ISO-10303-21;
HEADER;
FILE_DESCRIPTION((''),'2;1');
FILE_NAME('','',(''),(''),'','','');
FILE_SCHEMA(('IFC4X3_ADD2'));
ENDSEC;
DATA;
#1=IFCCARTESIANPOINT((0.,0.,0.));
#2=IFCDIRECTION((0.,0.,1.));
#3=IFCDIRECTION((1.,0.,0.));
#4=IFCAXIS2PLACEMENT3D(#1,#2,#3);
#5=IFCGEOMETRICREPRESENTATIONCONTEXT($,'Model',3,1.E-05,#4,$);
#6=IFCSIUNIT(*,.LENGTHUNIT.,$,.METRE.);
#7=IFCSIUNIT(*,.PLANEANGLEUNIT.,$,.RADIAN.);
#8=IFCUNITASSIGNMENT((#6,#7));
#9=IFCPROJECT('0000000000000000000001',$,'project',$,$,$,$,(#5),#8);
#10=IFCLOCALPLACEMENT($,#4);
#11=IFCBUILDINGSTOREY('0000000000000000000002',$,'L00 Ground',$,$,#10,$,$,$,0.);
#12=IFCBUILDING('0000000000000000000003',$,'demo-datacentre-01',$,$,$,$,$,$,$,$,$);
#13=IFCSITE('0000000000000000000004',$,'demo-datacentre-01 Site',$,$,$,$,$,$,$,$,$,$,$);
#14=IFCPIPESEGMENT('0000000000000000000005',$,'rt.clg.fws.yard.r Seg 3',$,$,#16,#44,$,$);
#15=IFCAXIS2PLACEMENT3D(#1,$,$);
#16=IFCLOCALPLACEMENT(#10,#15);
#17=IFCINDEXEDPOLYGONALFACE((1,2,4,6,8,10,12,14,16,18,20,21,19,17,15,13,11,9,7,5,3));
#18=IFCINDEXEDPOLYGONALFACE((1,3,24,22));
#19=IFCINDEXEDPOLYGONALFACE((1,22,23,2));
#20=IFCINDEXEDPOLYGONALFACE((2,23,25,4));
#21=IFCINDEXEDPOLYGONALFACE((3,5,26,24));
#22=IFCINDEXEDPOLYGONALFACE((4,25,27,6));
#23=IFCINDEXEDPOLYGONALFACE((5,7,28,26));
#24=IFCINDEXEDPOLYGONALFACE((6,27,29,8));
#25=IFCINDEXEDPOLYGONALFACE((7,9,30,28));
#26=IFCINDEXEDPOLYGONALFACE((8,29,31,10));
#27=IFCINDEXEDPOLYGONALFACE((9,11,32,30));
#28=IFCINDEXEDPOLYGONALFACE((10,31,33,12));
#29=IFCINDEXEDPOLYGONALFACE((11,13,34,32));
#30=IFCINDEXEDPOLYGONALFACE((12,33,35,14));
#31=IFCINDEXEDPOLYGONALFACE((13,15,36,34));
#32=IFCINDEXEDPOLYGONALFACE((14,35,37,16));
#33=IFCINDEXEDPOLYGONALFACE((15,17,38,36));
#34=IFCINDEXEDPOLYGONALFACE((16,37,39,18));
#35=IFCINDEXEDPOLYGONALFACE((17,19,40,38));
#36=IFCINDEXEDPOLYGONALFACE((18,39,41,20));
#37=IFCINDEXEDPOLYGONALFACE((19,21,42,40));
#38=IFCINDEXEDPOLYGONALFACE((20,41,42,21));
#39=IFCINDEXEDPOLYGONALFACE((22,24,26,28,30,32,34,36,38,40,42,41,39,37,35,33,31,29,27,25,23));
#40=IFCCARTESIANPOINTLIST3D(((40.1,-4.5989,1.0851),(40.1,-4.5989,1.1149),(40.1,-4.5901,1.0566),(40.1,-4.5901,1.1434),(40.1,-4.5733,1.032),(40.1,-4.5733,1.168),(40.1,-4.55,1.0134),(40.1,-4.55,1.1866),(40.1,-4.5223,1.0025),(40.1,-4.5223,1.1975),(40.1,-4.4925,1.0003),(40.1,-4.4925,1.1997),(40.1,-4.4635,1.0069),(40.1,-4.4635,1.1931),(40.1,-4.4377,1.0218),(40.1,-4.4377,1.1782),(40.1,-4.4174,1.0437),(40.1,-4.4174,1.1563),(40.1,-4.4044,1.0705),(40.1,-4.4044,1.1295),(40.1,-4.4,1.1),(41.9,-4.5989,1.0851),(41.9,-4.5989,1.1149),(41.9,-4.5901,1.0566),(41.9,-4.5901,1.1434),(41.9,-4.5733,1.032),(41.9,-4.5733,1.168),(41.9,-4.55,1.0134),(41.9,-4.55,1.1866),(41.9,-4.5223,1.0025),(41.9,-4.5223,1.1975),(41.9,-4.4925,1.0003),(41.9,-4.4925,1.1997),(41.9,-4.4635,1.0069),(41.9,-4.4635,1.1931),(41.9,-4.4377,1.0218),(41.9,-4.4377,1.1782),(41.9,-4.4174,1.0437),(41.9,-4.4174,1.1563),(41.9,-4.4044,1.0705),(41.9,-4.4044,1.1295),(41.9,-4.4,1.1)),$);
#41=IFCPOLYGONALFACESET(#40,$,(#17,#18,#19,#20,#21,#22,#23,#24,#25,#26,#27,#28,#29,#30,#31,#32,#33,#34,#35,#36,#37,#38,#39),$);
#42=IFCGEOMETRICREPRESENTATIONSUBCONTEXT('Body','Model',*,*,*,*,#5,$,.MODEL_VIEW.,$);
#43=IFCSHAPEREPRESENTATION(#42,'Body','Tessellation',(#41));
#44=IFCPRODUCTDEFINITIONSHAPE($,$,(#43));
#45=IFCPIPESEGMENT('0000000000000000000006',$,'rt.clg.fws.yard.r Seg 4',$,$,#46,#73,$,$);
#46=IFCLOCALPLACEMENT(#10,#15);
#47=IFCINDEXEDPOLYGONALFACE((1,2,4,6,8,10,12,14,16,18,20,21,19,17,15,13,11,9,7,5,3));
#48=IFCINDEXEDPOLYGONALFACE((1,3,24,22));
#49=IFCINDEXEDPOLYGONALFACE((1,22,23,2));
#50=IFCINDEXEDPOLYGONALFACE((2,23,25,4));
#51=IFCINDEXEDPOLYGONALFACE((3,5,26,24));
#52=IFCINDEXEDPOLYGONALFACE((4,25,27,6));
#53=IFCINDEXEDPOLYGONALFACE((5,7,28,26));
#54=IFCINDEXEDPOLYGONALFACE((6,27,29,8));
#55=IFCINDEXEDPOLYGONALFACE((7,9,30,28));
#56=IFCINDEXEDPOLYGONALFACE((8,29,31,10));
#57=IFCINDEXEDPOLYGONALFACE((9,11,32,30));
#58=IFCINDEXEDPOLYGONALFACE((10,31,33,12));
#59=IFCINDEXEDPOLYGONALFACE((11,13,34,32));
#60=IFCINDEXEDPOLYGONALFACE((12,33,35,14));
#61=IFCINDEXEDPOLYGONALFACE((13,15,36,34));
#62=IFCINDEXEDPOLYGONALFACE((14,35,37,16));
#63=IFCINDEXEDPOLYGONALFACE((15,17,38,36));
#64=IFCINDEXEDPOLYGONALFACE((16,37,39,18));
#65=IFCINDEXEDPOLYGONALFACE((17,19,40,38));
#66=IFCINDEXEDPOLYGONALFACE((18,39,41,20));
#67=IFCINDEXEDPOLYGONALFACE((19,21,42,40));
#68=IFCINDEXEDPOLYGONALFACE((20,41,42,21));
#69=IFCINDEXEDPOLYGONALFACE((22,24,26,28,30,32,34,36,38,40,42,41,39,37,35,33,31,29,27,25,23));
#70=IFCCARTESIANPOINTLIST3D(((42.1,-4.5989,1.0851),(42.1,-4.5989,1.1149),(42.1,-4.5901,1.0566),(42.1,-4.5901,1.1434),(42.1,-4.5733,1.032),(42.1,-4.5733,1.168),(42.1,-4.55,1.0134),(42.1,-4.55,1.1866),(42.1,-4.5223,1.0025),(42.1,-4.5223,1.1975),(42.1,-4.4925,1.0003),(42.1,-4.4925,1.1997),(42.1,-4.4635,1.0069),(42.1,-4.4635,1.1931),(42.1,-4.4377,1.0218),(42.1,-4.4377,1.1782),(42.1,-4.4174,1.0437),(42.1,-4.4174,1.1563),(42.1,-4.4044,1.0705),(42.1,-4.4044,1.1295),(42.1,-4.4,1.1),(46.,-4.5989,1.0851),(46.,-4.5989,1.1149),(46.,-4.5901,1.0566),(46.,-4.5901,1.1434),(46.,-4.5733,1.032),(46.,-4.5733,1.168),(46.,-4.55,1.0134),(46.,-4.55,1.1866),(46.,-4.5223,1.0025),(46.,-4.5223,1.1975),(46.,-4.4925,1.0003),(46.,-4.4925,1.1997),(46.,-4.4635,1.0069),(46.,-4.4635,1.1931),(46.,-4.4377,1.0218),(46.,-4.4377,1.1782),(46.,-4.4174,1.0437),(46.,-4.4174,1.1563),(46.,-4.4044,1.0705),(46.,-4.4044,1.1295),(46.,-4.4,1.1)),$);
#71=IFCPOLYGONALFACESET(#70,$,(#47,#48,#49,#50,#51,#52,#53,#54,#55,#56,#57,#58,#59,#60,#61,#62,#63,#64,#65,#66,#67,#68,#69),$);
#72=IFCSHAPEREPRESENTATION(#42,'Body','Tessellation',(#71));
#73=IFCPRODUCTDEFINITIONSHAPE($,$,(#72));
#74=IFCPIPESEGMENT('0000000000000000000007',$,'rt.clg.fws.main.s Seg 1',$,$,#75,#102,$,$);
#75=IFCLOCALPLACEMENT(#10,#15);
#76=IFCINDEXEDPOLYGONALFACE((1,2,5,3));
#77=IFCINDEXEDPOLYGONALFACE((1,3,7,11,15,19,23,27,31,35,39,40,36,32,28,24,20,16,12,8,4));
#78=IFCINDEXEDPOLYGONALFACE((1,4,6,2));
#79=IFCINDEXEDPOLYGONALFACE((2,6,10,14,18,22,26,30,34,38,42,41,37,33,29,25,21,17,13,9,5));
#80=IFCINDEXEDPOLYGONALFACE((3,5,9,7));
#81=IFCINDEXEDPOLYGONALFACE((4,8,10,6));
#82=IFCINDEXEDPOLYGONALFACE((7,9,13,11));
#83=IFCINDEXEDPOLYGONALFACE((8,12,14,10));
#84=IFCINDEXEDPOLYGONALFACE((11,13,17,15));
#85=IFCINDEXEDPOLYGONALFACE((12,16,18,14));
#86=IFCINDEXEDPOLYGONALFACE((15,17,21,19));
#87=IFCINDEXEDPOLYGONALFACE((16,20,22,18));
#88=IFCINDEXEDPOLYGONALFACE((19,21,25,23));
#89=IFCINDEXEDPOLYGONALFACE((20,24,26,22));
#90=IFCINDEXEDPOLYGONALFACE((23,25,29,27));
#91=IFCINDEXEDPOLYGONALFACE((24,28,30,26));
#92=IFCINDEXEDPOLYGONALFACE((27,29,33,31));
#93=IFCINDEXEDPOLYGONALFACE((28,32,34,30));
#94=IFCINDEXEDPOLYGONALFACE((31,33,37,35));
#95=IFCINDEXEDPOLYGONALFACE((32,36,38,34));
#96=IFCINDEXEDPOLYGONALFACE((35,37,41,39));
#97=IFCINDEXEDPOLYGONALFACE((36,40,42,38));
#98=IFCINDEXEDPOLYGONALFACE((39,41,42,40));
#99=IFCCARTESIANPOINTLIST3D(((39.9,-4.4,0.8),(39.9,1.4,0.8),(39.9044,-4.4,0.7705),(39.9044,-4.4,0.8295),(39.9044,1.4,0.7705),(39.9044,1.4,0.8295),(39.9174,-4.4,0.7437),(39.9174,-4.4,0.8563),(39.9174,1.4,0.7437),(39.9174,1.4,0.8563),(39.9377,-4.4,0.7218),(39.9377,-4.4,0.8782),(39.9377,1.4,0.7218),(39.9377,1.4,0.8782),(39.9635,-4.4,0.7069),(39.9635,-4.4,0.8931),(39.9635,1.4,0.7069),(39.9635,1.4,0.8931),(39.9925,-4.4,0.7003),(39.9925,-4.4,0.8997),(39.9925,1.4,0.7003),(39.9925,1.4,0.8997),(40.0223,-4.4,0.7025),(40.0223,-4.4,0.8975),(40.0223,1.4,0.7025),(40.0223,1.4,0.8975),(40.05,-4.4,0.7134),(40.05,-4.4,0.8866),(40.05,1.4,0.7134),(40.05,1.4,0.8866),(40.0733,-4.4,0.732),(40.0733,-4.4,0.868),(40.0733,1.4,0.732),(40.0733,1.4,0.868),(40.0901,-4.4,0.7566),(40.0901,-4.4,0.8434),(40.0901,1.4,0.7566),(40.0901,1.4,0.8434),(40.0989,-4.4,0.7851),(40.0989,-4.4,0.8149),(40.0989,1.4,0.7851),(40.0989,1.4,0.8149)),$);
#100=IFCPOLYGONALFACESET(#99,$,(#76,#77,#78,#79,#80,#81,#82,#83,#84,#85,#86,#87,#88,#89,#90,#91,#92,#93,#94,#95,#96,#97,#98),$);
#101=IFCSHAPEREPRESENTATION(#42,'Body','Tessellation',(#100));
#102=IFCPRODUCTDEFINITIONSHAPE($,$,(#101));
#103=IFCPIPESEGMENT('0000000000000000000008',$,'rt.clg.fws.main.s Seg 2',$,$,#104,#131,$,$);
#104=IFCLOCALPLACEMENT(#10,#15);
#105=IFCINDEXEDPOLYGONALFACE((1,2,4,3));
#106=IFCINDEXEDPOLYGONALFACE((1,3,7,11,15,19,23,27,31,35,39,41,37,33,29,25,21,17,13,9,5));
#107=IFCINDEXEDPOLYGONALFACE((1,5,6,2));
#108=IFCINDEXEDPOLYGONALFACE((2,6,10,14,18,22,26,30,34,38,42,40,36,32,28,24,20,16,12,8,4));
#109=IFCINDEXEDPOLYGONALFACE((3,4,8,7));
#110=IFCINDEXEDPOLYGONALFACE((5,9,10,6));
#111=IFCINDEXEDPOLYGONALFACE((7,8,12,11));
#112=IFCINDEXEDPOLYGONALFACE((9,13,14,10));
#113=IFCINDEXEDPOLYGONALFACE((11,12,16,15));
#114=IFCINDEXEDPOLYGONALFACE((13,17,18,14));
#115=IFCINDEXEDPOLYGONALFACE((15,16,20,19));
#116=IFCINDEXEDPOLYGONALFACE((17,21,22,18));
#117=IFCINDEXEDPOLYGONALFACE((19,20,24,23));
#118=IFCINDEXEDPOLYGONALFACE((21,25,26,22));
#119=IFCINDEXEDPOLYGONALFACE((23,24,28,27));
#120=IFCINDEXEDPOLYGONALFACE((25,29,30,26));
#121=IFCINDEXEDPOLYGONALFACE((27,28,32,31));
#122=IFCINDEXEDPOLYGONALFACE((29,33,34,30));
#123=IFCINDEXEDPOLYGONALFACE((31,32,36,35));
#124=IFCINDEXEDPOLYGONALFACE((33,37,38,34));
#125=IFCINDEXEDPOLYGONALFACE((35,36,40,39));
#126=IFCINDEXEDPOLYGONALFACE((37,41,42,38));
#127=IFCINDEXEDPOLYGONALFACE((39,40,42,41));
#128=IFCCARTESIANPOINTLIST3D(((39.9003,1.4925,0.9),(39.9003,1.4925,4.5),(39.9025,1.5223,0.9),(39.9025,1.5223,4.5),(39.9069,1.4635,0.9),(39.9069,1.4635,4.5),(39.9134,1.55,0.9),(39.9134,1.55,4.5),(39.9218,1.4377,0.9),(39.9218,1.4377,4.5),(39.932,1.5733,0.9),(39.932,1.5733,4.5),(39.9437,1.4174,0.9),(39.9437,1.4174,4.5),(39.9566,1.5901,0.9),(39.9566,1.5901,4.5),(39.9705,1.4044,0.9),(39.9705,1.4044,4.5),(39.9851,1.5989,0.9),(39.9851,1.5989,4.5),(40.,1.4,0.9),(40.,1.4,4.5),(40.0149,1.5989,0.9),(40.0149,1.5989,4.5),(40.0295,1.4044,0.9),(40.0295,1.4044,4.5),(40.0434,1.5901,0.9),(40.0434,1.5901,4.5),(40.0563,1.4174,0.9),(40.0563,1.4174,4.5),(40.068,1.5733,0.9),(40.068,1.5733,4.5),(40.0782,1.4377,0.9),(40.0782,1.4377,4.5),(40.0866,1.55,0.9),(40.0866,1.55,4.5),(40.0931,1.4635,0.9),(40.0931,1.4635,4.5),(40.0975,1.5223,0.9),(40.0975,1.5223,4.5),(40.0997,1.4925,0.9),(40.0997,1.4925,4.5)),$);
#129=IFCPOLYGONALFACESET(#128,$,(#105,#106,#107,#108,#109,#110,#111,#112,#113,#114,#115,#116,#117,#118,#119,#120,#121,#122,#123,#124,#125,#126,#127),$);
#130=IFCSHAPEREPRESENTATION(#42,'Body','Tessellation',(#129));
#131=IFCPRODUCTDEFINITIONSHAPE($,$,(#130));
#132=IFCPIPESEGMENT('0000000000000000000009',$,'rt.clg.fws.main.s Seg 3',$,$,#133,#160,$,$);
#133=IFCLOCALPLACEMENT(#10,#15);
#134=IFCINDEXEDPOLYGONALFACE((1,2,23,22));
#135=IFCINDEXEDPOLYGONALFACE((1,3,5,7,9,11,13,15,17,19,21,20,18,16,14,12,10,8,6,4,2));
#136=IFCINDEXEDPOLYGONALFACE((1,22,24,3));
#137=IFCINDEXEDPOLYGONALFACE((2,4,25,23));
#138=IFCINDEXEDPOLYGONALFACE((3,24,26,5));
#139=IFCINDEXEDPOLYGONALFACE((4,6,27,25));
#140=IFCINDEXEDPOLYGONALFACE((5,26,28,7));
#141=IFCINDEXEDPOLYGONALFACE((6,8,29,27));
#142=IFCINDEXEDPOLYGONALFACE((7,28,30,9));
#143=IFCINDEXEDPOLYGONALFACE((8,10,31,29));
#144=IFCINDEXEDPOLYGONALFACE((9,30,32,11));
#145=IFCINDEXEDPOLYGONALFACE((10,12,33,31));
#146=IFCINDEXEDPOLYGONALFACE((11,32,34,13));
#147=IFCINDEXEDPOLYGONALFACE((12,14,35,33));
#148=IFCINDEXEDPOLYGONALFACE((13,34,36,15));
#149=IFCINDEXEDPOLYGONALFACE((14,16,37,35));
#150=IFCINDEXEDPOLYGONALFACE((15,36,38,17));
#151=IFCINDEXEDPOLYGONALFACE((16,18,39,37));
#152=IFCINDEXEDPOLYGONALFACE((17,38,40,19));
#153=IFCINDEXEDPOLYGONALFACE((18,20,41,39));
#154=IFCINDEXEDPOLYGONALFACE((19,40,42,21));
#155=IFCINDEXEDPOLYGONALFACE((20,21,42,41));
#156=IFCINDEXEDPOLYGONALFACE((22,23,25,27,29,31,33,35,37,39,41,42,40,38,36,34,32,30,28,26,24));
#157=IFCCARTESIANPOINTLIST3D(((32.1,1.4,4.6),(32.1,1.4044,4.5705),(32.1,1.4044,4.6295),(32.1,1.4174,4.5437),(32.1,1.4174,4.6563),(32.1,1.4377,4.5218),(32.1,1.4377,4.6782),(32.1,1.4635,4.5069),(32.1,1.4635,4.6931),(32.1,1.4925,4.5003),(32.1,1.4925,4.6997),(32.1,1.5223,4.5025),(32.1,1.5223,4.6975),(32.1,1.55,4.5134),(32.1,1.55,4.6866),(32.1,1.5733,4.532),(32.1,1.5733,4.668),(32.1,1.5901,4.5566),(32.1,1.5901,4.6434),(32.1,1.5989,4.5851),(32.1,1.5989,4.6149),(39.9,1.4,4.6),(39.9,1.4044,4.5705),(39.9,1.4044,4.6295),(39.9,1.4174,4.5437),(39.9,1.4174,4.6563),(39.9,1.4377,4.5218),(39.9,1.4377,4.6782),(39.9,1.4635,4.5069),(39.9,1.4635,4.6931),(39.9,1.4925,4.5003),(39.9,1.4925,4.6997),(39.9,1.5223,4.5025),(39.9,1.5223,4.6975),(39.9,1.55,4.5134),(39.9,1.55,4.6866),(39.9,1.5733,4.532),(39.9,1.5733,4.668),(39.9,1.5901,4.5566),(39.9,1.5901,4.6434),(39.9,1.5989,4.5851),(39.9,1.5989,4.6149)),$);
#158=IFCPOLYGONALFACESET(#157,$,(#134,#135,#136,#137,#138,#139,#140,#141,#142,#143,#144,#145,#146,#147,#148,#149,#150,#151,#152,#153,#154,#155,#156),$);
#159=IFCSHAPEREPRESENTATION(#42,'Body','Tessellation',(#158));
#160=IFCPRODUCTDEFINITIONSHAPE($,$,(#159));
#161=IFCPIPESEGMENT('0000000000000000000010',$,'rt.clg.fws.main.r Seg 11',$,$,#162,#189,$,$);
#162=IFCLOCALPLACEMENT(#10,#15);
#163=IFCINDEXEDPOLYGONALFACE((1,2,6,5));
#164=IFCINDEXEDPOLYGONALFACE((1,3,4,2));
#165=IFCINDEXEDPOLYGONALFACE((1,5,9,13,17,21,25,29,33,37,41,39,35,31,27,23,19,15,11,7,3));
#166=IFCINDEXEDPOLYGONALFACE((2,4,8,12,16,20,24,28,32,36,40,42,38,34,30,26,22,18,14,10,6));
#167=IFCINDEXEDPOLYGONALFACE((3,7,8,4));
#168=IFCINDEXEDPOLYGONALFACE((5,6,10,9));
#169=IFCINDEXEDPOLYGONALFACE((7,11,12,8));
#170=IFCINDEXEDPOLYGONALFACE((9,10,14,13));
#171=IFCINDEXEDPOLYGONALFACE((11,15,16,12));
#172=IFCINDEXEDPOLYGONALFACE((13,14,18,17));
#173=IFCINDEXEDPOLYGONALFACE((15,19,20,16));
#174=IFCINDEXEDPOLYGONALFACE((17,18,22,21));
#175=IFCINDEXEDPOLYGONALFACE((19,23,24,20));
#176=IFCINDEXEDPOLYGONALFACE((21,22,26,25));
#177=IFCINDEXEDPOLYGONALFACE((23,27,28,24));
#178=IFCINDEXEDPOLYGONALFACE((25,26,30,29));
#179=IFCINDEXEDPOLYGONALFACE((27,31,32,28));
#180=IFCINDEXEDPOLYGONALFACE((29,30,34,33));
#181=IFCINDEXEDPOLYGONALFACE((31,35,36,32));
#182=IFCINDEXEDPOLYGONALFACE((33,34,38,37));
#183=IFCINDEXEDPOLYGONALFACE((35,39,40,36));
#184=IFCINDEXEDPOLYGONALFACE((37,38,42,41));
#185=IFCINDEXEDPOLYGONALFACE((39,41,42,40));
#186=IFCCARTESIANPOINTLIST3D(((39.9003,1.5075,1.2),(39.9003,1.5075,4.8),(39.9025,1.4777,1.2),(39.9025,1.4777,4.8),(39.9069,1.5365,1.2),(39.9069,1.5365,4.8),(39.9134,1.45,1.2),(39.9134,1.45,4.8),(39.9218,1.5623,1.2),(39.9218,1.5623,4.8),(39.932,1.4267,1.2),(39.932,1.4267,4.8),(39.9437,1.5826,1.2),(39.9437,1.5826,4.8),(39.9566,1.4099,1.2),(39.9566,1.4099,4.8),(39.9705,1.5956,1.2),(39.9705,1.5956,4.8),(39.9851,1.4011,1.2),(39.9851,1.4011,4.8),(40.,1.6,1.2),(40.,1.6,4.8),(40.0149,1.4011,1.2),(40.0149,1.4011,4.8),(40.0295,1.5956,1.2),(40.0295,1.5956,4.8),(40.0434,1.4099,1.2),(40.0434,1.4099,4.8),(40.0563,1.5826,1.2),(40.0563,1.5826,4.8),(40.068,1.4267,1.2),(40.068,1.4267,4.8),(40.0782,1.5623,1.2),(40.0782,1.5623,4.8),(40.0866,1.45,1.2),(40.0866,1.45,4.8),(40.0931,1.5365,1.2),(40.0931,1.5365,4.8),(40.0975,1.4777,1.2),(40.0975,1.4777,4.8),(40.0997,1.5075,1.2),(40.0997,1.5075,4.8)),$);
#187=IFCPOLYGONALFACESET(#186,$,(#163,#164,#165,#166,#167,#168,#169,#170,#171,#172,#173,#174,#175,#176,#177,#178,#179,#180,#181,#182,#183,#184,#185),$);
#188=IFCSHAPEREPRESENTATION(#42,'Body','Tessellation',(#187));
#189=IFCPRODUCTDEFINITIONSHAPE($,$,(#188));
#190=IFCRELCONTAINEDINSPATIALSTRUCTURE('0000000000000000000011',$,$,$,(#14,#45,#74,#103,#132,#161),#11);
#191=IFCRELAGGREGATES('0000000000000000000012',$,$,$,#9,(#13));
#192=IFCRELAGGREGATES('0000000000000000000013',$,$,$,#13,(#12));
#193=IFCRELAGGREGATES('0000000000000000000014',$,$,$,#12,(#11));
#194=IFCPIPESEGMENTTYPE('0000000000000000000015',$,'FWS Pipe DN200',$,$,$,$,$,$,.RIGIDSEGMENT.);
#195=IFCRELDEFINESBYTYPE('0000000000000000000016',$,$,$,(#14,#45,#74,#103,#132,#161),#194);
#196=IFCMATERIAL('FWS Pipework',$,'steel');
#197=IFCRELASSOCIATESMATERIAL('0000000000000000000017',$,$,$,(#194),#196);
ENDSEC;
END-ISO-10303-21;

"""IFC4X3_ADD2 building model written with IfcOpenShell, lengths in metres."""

from ifc_helpers import new_model, si_unit, frame, origin_with_axes, place, context, subcontext, project, spatial, circle, extrude, material, type_object, element, save


model = new_model("IFC4X3_ADD2")

# Units and contexts
model_context = context("Model", 3, precision=1e-05, world=origin_with_axes())
body_context = subcontext(model_context, "Body", "Model", "MODEL_VIEW")
ifc_project = project(units=[si_unit("LENGTHUNIT", "METRE"), si_unit("PLANEANGLEUNIT", "RADIAN")], contexts=[model_context])

# Site, building, storey
site = spatial("IfcSite", under=ifc_project, Name="demo-datacentre-01 Site")
building = spatial("IfcBuilding", under=site, Name="demo-datacentre-01")
storey_placement = place(None, origin_with_axes())
storey = spatial("IfcBuildingStorey", under=building, at=storey_placement, Name="L00 Ground", Elevation=0.0)

# Shared definitions
ifc_material = material(Name="FWS Pipework", Category="steel")

# Pipe segments
pipe_segment_type_1 = type_object("IfcPipeSegmentType", Name="FWS Pipe DN200", PredefinedType="RIGIDSEGMENT", material=ifc_material)
for number, where, z_axis, x_axis, name in (
    (1, (40.1, -4.5, 1.1), (1.0, 0.0, 0.0), (0.0, 1.0, 0.0), "rt.clg.fws.yard.r Seg 3"),
):
    element("IfcPipeSegment", number, at=place(storey_placement, frame(where, z_axis=z_axis, x_axis=x_axis)), inside=storey, type_object=pipe_segment_type_1, Name=name, context=body_context, shape_type="SweptSolid", body=[
        extrude(circle(Radius=0.1), origin_with_axes(), (0.0, 0.0, 1.0), 1.8),
    ])
pipe_segment_1_placement = place(storey_placement, frame((42.1, -4.5, 1.1), z_axis=(1.0, 0.0, 0.0), x_axis=(0.0, 1.0, 0.0)))
element("IfcPipeSegment", 2, at=pipe_segment_1_placement, inside=storey, type_object=pipe_segment_type_1, Name="rt.clg.fws.yard.r Seg 4", context=body_context, shape_type="SweptSolid", body=[
    extrude(circle(Radius=0.1), origin_with_axes(), (0.0, 0.0, 1.0), 3.9),
])
pipe_segment_2_placement = place(storey_placement, frame((40.0, -4.4, 0.8), z_axis=(0.0, 1.0, 0.0), x_axis=(-1.0, 0.0, 0.0)))
element("IfcPipeSegment", 3, at=pipe_segment_2_placement, inside=storey, type_object=pipe_segment_type_1, Name="rt.clg.fws.main.s Seg 1", context=body_context, shape_type="SweptSolid", body=[
    extrude(circle(Radius=0.1), origin_with_axes(), (0.0, 0.0, 1.0), 5.8),
])
pipe_segment_3_placement = place(storey_placement, frame((40.0, 1.5, 0.9), z_axis=(0.0, 0.0, 1.0), x_axis=(0.0, -1.0, 0.0)))
element("IfcPipeSegment", 4, at=pipe_segment_3_placement, inside=storey, type_object=pipe_segment_type_1, Name="rt.clg.fws.main.s Seg 2", context=body_context, shape_type="SweptSolid", body=[
    extrude(circle(Radius=0.1), origin_with_axes(), (0.0, 0.0, 1.0), 3.6),
])
pipe_segment_4_placement = place(storey_placement, frame((39.9, 1.5, 4.6), z_axis=(-1.0, 0.0, 0.0), x_axis=(0.0, -1.0, 0.0)))
element("IfcPipeSegment", 5, at=pipe_segment_4_placement, inside=storey, type_object=pipe_segment_type_1, Name="rt.clg.fws.main.s Seg 3", context=body_context, shape_type="SweptSolid", body=[
    extrude(circle(Radius=0.1), origin_with_axes(), (0.0, 0.0, 1.0), 7.8),
])
pipe_segment_5_placement = place(storey_placement, frame((40.0, 1.5, 4.8), z_axis=(0.0, 0.0, -1.0), x_axis=(0.0, 1.0, 0.0)))
element("IfcPipeSegment", 6, at=pipe_segment_5_placement, inside=storey, type_object=pipe_segment_type_1, Name="rt.clg.fws.main.r Seg 11", context=body_context, shape_type="SweptSolid", body=[
    extrude(circle(Radius=0.1), origin_with_axes(), (0.0, 0.0, 1.0), 3.6),
])

save(model, "model.ifc")
